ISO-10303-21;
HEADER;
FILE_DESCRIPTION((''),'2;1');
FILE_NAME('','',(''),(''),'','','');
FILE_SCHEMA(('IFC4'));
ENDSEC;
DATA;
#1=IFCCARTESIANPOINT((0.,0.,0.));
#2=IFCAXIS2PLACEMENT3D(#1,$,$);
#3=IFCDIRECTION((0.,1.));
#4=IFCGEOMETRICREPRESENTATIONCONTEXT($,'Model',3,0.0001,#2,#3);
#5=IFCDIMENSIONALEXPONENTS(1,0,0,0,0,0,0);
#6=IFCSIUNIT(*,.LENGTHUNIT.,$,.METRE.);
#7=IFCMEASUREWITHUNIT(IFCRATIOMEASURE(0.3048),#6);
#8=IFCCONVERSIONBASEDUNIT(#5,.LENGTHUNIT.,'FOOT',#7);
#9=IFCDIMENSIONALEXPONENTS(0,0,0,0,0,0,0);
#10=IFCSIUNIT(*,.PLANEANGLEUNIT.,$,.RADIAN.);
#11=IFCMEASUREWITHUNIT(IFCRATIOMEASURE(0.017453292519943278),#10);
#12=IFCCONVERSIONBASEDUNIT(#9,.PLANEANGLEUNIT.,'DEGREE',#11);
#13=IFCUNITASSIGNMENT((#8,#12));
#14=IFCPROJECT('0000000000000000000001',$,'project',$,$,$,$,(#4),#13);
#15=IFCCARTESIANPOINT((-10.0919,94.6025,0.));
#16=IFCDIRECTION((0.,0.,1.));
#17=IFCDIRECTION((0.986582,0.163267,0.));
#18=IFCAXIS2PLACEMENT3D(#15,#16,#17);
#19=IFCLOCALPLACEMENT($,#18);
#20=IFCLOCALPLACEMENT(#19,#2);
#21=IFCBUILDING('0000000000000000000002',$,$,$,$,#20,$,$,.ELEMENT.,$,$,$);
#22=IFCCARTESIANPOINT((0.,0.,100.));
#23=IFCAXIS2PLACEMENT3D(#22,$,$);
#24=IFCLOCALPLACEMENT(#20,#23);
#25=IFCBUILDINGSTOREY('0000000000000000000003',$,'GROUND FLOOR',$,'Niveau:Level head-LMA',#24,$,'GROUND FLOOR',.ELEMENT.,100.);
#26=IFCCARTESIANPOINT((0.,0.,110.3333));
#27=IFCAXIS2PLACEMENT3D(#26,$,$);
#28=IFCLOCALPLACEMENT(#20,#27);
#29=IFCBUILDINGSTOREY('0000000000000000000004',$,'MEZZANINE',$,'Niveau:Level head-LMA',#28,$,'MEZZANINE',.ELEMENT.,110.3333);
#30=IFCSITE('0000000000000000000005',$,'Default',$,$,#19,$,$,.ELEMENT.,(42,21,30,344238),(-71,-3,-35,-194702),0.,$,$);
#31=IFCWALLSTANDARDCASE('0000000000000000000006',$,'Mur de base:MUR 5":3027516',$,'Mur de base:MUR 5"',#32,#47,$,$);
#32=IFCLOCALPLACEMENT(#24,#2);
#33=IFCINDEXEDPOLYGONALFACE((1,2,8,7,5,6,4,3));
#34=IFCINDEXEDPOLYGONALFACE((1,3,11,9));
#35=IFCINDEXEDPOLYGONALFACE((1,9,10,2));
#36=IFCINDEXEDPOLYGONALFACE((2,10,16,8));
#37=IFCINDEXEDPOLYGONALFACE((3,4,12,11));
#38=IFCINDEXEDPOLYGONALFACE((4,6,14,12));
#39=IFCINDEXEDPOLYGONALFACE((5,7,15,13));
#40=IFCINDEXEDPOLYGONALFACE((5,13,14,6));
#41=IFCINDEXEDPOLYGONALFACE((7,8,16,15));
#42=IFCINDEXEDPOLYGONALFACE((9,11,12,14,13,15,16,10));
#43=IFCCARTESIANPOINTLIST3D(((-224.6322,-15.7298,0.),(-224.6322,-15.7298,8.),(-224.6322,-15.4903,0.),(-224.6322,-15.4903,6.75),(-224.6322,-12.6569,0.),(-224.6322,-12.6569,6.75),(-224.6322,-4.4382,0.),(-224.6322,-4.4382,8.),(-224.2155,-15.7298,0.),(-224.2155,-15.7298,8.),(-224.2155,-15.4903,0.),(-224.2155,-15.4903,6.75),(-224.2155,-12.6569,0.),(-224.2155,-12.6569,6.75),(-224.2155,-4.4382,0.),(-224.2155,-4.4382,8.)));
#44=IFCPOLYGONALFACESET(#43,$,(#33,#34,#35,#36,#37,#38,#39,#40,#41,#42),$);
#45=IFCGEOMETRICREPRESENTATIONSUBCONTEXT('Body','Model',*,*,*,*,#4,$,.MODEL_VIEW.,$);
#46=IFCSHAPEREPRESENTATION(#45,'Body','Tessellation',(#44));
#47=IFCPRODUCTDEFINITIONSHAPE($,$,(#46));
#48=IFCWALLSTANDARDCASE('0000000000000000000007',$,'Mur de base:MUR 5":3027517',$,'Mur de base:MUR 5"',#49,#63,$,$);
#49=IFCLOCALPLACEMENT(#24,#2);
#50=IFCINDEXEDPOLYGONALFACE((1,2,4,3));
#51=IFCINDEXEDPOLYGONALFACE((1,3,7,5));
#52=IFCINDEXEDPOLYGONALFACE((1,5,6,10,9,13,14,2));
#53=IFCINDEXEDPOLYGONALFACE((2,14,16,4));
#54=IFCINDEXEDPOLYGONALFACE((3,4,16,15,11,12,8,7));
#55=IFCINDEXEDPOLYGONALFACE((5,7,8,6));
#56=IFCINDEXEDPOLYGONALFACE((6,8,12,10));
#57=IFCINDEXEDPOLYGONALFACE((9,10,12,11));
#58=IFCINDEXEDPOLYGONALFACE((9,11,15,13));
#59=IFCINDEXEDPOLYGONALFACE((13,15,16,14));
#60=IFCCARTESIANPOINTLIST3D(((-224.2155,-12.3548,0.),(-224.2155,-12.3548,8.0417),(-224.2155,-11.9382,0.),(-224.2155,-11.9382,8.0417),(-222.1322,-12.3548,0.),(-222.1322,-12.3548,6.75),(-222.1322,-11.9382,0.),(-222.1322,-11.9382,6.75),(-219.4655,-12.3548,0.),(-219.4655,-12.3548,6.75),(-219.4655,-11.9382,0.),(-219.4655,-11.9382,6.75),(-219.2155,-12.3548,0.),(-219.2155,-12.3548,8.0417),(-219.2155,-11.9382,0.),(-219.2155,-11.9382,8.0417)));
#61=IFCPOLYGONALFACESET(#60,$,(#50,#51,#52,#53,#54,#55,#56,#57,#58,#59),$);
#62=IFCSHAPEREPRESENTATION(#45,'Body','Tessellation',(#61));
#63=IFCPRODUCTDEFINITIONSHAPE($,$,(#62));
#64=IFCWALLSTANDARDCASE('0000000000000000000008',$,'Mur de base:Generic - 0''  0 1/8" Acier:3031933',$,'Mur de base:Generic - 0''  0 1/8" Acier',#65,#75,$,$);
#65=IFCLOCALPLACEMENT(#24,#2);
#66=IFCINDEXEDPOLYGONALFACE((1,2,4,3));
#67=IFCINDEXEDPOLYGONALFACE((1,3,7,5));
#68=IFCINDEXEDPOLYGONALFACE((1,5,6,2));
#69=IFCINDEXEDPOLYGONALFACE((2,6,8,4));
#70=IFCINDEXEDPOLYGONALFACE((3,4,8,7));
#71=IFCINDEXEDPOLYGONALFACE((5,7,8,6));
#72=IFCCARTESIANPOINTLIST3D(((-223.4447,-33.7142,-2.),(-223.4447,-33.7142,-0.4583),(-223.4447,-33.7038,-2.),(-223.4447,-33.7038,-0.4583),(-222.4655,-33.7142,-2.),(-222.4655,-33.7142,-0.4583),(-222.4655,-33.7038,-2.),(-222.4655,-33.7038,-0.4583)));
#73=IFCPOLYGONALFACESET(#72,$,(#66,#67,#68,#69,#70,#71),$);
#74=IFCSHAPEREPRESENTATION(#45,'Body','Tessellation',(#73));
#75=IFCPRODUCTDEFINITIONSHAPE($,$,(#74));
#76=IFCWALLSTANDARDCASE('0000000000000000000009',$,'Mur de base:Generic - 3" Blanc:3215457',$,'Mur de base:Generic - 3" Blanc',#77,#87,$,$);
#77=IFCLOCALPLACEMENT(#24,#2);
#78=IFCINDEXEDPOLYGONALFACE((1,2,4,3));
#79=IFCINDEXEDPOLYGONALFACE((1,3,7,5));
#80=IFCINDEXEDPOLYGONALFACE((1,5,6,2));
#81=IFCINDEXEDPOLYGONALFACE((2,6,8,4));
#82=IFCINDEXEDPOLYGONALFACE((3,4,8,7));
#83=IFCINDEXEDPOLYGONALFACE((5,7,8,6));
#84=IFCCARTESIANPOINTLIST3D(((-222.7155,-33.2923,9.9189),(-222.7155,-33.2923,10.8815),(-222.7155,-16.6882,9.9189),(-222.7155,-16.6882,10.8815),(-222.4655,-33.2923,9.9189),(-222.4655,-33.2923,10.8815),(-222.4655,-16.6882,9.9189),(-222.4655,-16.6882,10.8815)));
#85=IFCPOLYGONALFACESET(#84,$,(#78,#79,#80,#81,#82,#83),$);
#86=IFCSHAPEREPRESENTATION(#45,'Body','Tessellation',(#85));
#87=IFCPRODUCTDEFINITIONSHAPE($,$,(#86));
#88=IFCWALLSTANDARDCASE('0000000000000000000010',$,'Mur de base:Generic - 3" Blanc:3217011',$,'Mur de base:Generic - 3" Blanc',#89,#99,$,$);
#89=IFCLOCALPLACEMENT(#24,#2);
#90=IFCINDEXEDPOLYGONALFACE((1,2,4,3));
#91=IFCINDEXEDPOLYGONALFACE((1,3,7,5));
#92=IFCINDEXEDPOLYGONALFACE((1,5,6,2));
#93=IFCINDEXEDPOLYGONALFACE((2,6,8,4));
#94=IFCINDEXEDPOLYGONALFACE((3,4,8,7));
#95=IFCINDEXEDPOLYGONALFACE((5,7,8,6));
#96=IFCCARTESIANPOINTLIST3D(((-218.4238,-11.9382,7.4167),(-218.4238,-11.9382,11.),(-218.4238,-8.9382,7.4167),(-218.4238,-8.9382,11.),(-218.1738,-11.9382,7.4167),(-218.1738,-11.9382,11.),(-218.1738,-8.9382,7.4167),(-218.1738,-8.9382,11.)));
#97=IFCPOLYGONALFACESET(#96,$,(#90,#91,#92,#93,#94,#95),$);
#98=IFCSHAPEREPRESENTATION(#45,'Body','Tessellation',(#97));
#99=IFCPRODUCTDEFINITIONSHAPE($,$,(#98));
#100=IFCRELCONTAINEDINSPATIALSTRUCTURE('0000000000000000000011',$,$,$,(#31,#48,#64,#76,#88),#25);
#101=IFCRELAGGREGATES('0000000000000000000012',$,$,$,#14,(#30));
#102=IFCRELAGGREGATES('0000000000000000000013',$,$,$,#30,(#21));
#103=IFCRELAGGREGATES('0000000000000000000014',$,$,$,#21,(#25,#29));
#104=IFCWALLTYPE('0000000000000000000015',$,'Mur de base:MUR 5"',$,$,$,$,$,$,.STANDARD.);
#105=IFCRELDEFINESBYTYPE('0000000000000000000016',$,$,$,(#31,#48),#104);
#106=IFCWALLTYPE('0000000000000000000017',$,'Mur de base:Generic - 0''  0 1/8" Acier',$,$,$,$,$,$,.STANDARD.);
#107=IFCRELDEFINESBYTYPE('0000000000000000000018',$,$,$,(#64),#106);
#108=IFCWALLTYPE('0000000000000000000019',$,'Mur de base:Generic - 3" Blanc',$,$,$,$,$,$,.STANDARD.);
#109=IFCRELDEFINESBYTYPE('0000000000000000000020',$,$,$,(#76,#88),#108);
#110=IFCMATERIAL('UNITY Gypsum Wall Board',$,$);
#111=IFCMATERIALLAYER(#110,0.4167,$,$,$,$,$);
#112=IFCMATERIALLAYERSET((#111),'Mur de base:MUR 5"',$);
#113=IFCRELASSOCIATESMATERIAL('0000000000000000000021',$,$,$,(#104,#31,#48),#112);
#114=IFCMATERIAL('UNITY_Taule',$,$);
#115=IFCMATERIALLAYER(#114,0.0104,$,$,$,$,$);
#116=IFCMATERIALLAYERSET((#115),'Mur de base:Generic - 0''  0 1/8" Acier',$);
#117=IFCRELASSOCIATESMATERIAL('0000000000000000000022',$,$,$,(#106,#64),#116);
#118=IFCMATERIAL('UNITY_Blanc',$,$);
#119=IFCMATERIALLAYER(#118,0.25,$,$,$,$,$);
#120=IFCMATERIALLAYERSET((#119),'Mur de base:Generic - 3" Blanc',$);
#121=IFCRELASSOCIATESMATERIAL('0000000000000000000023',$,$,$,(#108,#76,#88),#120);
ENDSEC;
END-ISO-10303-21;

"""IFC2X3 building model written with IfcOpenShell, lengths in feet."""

from ifc_helpers import new_model, entity, si_unit, converted_unit, direction, frame, frame_2d, origin, place, context, subcontext, project, spatial, rectangle, extrude, material, layer, layer_set, layer_usage, type_object, element, save


model = new_model("IFC2X3")

# Units and contexts
model_context = context("Model", 3, precision=0.0001, world=origin(), true_north=direction((0.0, 1.0)))
body_context = subcontext(model_context, "Body", "Model", "MODEL_VIEW")
ifc_project = project(units=[converted_unit("LENGTHUNIT", "FOOT", entity("IfcRatioMeasure", 0.3048), si_unit("LENGTHUNIT", "METRE"), dimensions=[1, 0, 0, 0, 0, 0, 0]), converted_unit("PLANEANGLEUNIT", "DEGREE", entity("IfcRatioMeasure", 0.017453292519943278), si_unit("PLANEANGLEUNIT", "RADIAN"), dimensions=[0, 0, 0, 0, 0, 0, 0])], contexts=[model_context])

# Site, building, storey
site_placement = place(None, frame((-10.0919, 94.6025, 0.0), z_axis=(0.0, 0.0, 1.0), x_axis=(0.986582, 0.163267, 0.0)))
site = spatial("IfcSite", under=ifc_project, at=site_placement, Name="Default", CompositionType="ELEMENT", RefLatitude=(42, 21, 30, 344238), RefLongitude=(-71, -3, -35, -194702), RefElevation=0.0)
building_placement = place(site_placement, origin())
building = spatial("IfcBuilding", under=site, at=building_placement, CompositionType="ELEMENT")
storey_1_placement = place(building_placement, frame((0.0, 0.0, 100.0)))
storey_1 = spatial("IfcBuildingStorey", under=building, at=storey_1_placement, Name="GROUND FLOOR", ObjectType="Niveau:Level head-LMA", LongName="GROUND FLOOR", CompositionType="ELEMENT", Elevation=100.0)

# Shared definitions
ifc_material_1 = material(Name="UNITY_Blanc")

# Shared definitions
storey_2_placement = place(building_placement, frame((0.0, 0.0, 110.3333)))
storey_2 = spatial("IfcBuildingStorey", under=building, at=storey_2_placement, Name="MEZZANINE", ObjectType="Niveau:Level head-LMA", LongName="MEZZANINE", CompositionType="ELEMENT", Elevation=110.3333)

# Walls, openings
ifc_material_2 = material(Name="UNITY Gypsum Wall Board")
ifc_layer_1 = layer(ifc_material_2, 0.4167)
ifc_layer_set_1 = layer_set([ifc_layer_1], Name="Mur de base:MUR 5\"")
ifc_layer_usage_1 = layer_usage(ifc_layer_set_1, "AXIS2", "NEGATIVE", 0.2083)
wall_type_1 = type_object("IfcWallType", Name="Mur de base:MUR 5\"", PredefinedType="STANDARD", material=ifc_layer_set_1)
wall_1_placement = place(storey_1_placement, frame((-224.4238, -15.7298, 0.0), z_axis=(0.0, 0.0, 1.0), x_axis=(0.0, 1.0, 0.0)))
wall_1 = element("IfcWallStandardCase", 1, at=wall_1_placement, inside=storey_1, type_object=wall_type_1, material=ifc_layer_usage_1, Name="Mur de base:MUR 5\":3027516", ObjectType="Mur de base:MUR 5\"", context=body_context, shape_type="SweptSolid", body=[
    extrude(rectangle(XDim=11.2917, YDim=0.4167, at=frame_2d((5.6458, 0.0), x_axis=(-1.0, 0.0))), origin(), (0.0, 0.0, 1.0), 8.0),
])
opening_1_placement = place(wall_1_placement, frame((15.7298, -224.4238, 0.0), z_axis=(0.0, 0.0, 1.0), x_axis=(0.0, -1.0, 0.0)))
element("IfcOpeningElement", 2, at=opening_1_placement, cuts=wall_1, ObjectType="Opening", context=body_context, shape_type="SweptSolid", body=[
    extrude(rectangle(XDim=6.75, YDim=2.8333, at=frame_2d((0.0, 0.0), x_axis=(1.0, 0.0))), frame((-219.2155, -14.0736, 3.375), z_axis=(-1.0, 0.0, 0.0), x_axis=(0.0, 0.0, 1.0)), (0.0, 0.0, 1.0), 10.0),
])
ifc_layer_usage_2 = layer_usage(ifc_layer_set_1, "AXIS2", "POSITIVE", -0.2083)
wall_2_placement = place(storey_1_placement, frame((-224.2155, -12.1465, 0.0)))
wall_2 = element("IfcWallStandardCase", 3, at=wall_2_placement, inside=storey_1, type_object=wall_type_1, material=ifc_layer_usage_2, Name="Mur de base:MUR 5\":3027517", ObjectType="Mur de base:MUR 5\"", context=body_context, shape_type="SweptSolid", body=[
    extrude(rectangle(XDim=5.0, YDim=0.4167, at=frame_2d((2.5, 0.0), x_axis=(-1.0, 0.0))), origin(), (0.0, 0.0, 1.0), 8.0417),
])
opening_2_placement = place(wall_2_placement, frame((224.2155, 12.1465, 0.0)))
element("IfcOpeningElement", 4, at=opening_2_placement, cuts=wall_2, ObjectType="Opening", context=body_context, shape_type="SweptSolid", body=[
    extrude(rectangle(XDim=6.75, YDim=2.6667, at=frame_2d((0.0, 0.0), x_axis=(0.0, 1.0))), frame((-220.7988, -17.3548, 3.375), z_axis=(0.0, 1.0, 0.0), x_axis=(-1.0, 0.0, 0.0)), (0.0, 0.0, 1.0), 10.0),
])

# Walls
ifc_material_3 = material(Name="UNITY_Taule")
ifc_layer_2 = layer(ifc_material_3, 0.0104)
ifc_layer_set_2 = layer_set([ifc_layer_2], Name="Mur de base:Generic - 0'  0 1/8\" Acier")
ifc_layer_usage_3 = layer_usage(ifc_layer_set_2, "AXIS2", "NEGATIVE", 0.0052)
wall_type_2 = type_object("IfcWallType", Name="Mur de base:Generic - 0'  0 1/8\" Acier", PredefinedType="STANDARD", material=ifc_layer_set_2)
wall_3_placement = place(storey_1_placement, frame((-222.4655, -33.709, -2.0), z_axis=(0.0, 0.0, 1.0), x_axis=(-1.0, 0.0, 0.0)))
element("IfcWallStandardCase", 5, at=wall_3_placement, inside=storey_1, type_object=wall_type_2, material=ifc_layer_usage_3, Name="Mur de base:Generic - 0'  0 1/8\" Acier:3031933", ObjectType="Mur de base:Generic - 0'  0 1/8\" Acier", context=body_context, shape_type="SweptSolid", body=[
    extrude(rectangle(XDim=0.9792, YDim=0.0104, at=frame_2d((0.4896, 0.0), x_axis=(-1.0, 0.0))), origin(), (0.0, 0.0, 1.0), 1.5417),
])
ifc_layer_3 = layer(ifc_material_1, 0.25)
ifc_layer_set_3 = layer_set([ifc_layer_3], Name="Mur de base:Generic - 3\" Blanc")
ifc_layer_usage_4 = layer_usage(ifc_layer_set_3, "AXIS2", "POSITIVE", -0.125)
wall_type_3 = type_object("IfcWallType", Name="Mur de base:Generic - 3\" Blanc", PredefinedType="STANDARD", material=ifc_layer_set_3)
wall_4_placement = place(storey_1_placement, frame((-222.5905, -16.6882, 9.9189), z_axis=(0.0, 0.0, 1.0), x_axis=(0.0, -1.0, 0.0)))
element("IfcWallStandardCase", 6, at=wall_4_placement, inside=storey_1, type_object=wall_type_3, material=ifc_layer_usage_4, Name="Mur de base:Generic - 3\" Blanc:3215457", ObjectType="Mur de base:Generic - 3\" Blanc", context=body_context, shape_type="SweptSolid", body=[
    extrude(rectangle(XDim=16.6042, YDim=0.25, at=frame_2d((8.3021, 0.0), x_axis=(-1.0, 0.0))), origin(), (0.0, 0.0, 1.0), 0.9627),
])
ifc_layer_usage_5 = layer_usage(ifc_layer_set_3, "AXIS2", "POSITIVE", -0.125)
wall_5_placement = place(storey_1_placement, frame((-218.2988, -11.9382, 7.4167), z_axis=(0.0, 0.0, 1.0), x_axis=(0.0, 1.0, 0.0)))
element("IfcWallStandardCase", 7, at=wall_5_placement, inside=storey_1, type_object=wall_type_3, material=ifc_layer_usage_5, Name="Mur de base:Generic - 3\" Blanc:3217011", ObjectType="Mur de base:Generic - 3\" Blanc", context=body_context, shape_type="SweptSolid", body=[
    extrude(rectangle(XDim=3.0, YDim=0.25, at=frame_2d((1.5, 0.0), x_axis=(-1.0, 0.0))), origin(), (0.0, 0.0, 1.0), 3.5833),
])

save(model, "model.ifc")
